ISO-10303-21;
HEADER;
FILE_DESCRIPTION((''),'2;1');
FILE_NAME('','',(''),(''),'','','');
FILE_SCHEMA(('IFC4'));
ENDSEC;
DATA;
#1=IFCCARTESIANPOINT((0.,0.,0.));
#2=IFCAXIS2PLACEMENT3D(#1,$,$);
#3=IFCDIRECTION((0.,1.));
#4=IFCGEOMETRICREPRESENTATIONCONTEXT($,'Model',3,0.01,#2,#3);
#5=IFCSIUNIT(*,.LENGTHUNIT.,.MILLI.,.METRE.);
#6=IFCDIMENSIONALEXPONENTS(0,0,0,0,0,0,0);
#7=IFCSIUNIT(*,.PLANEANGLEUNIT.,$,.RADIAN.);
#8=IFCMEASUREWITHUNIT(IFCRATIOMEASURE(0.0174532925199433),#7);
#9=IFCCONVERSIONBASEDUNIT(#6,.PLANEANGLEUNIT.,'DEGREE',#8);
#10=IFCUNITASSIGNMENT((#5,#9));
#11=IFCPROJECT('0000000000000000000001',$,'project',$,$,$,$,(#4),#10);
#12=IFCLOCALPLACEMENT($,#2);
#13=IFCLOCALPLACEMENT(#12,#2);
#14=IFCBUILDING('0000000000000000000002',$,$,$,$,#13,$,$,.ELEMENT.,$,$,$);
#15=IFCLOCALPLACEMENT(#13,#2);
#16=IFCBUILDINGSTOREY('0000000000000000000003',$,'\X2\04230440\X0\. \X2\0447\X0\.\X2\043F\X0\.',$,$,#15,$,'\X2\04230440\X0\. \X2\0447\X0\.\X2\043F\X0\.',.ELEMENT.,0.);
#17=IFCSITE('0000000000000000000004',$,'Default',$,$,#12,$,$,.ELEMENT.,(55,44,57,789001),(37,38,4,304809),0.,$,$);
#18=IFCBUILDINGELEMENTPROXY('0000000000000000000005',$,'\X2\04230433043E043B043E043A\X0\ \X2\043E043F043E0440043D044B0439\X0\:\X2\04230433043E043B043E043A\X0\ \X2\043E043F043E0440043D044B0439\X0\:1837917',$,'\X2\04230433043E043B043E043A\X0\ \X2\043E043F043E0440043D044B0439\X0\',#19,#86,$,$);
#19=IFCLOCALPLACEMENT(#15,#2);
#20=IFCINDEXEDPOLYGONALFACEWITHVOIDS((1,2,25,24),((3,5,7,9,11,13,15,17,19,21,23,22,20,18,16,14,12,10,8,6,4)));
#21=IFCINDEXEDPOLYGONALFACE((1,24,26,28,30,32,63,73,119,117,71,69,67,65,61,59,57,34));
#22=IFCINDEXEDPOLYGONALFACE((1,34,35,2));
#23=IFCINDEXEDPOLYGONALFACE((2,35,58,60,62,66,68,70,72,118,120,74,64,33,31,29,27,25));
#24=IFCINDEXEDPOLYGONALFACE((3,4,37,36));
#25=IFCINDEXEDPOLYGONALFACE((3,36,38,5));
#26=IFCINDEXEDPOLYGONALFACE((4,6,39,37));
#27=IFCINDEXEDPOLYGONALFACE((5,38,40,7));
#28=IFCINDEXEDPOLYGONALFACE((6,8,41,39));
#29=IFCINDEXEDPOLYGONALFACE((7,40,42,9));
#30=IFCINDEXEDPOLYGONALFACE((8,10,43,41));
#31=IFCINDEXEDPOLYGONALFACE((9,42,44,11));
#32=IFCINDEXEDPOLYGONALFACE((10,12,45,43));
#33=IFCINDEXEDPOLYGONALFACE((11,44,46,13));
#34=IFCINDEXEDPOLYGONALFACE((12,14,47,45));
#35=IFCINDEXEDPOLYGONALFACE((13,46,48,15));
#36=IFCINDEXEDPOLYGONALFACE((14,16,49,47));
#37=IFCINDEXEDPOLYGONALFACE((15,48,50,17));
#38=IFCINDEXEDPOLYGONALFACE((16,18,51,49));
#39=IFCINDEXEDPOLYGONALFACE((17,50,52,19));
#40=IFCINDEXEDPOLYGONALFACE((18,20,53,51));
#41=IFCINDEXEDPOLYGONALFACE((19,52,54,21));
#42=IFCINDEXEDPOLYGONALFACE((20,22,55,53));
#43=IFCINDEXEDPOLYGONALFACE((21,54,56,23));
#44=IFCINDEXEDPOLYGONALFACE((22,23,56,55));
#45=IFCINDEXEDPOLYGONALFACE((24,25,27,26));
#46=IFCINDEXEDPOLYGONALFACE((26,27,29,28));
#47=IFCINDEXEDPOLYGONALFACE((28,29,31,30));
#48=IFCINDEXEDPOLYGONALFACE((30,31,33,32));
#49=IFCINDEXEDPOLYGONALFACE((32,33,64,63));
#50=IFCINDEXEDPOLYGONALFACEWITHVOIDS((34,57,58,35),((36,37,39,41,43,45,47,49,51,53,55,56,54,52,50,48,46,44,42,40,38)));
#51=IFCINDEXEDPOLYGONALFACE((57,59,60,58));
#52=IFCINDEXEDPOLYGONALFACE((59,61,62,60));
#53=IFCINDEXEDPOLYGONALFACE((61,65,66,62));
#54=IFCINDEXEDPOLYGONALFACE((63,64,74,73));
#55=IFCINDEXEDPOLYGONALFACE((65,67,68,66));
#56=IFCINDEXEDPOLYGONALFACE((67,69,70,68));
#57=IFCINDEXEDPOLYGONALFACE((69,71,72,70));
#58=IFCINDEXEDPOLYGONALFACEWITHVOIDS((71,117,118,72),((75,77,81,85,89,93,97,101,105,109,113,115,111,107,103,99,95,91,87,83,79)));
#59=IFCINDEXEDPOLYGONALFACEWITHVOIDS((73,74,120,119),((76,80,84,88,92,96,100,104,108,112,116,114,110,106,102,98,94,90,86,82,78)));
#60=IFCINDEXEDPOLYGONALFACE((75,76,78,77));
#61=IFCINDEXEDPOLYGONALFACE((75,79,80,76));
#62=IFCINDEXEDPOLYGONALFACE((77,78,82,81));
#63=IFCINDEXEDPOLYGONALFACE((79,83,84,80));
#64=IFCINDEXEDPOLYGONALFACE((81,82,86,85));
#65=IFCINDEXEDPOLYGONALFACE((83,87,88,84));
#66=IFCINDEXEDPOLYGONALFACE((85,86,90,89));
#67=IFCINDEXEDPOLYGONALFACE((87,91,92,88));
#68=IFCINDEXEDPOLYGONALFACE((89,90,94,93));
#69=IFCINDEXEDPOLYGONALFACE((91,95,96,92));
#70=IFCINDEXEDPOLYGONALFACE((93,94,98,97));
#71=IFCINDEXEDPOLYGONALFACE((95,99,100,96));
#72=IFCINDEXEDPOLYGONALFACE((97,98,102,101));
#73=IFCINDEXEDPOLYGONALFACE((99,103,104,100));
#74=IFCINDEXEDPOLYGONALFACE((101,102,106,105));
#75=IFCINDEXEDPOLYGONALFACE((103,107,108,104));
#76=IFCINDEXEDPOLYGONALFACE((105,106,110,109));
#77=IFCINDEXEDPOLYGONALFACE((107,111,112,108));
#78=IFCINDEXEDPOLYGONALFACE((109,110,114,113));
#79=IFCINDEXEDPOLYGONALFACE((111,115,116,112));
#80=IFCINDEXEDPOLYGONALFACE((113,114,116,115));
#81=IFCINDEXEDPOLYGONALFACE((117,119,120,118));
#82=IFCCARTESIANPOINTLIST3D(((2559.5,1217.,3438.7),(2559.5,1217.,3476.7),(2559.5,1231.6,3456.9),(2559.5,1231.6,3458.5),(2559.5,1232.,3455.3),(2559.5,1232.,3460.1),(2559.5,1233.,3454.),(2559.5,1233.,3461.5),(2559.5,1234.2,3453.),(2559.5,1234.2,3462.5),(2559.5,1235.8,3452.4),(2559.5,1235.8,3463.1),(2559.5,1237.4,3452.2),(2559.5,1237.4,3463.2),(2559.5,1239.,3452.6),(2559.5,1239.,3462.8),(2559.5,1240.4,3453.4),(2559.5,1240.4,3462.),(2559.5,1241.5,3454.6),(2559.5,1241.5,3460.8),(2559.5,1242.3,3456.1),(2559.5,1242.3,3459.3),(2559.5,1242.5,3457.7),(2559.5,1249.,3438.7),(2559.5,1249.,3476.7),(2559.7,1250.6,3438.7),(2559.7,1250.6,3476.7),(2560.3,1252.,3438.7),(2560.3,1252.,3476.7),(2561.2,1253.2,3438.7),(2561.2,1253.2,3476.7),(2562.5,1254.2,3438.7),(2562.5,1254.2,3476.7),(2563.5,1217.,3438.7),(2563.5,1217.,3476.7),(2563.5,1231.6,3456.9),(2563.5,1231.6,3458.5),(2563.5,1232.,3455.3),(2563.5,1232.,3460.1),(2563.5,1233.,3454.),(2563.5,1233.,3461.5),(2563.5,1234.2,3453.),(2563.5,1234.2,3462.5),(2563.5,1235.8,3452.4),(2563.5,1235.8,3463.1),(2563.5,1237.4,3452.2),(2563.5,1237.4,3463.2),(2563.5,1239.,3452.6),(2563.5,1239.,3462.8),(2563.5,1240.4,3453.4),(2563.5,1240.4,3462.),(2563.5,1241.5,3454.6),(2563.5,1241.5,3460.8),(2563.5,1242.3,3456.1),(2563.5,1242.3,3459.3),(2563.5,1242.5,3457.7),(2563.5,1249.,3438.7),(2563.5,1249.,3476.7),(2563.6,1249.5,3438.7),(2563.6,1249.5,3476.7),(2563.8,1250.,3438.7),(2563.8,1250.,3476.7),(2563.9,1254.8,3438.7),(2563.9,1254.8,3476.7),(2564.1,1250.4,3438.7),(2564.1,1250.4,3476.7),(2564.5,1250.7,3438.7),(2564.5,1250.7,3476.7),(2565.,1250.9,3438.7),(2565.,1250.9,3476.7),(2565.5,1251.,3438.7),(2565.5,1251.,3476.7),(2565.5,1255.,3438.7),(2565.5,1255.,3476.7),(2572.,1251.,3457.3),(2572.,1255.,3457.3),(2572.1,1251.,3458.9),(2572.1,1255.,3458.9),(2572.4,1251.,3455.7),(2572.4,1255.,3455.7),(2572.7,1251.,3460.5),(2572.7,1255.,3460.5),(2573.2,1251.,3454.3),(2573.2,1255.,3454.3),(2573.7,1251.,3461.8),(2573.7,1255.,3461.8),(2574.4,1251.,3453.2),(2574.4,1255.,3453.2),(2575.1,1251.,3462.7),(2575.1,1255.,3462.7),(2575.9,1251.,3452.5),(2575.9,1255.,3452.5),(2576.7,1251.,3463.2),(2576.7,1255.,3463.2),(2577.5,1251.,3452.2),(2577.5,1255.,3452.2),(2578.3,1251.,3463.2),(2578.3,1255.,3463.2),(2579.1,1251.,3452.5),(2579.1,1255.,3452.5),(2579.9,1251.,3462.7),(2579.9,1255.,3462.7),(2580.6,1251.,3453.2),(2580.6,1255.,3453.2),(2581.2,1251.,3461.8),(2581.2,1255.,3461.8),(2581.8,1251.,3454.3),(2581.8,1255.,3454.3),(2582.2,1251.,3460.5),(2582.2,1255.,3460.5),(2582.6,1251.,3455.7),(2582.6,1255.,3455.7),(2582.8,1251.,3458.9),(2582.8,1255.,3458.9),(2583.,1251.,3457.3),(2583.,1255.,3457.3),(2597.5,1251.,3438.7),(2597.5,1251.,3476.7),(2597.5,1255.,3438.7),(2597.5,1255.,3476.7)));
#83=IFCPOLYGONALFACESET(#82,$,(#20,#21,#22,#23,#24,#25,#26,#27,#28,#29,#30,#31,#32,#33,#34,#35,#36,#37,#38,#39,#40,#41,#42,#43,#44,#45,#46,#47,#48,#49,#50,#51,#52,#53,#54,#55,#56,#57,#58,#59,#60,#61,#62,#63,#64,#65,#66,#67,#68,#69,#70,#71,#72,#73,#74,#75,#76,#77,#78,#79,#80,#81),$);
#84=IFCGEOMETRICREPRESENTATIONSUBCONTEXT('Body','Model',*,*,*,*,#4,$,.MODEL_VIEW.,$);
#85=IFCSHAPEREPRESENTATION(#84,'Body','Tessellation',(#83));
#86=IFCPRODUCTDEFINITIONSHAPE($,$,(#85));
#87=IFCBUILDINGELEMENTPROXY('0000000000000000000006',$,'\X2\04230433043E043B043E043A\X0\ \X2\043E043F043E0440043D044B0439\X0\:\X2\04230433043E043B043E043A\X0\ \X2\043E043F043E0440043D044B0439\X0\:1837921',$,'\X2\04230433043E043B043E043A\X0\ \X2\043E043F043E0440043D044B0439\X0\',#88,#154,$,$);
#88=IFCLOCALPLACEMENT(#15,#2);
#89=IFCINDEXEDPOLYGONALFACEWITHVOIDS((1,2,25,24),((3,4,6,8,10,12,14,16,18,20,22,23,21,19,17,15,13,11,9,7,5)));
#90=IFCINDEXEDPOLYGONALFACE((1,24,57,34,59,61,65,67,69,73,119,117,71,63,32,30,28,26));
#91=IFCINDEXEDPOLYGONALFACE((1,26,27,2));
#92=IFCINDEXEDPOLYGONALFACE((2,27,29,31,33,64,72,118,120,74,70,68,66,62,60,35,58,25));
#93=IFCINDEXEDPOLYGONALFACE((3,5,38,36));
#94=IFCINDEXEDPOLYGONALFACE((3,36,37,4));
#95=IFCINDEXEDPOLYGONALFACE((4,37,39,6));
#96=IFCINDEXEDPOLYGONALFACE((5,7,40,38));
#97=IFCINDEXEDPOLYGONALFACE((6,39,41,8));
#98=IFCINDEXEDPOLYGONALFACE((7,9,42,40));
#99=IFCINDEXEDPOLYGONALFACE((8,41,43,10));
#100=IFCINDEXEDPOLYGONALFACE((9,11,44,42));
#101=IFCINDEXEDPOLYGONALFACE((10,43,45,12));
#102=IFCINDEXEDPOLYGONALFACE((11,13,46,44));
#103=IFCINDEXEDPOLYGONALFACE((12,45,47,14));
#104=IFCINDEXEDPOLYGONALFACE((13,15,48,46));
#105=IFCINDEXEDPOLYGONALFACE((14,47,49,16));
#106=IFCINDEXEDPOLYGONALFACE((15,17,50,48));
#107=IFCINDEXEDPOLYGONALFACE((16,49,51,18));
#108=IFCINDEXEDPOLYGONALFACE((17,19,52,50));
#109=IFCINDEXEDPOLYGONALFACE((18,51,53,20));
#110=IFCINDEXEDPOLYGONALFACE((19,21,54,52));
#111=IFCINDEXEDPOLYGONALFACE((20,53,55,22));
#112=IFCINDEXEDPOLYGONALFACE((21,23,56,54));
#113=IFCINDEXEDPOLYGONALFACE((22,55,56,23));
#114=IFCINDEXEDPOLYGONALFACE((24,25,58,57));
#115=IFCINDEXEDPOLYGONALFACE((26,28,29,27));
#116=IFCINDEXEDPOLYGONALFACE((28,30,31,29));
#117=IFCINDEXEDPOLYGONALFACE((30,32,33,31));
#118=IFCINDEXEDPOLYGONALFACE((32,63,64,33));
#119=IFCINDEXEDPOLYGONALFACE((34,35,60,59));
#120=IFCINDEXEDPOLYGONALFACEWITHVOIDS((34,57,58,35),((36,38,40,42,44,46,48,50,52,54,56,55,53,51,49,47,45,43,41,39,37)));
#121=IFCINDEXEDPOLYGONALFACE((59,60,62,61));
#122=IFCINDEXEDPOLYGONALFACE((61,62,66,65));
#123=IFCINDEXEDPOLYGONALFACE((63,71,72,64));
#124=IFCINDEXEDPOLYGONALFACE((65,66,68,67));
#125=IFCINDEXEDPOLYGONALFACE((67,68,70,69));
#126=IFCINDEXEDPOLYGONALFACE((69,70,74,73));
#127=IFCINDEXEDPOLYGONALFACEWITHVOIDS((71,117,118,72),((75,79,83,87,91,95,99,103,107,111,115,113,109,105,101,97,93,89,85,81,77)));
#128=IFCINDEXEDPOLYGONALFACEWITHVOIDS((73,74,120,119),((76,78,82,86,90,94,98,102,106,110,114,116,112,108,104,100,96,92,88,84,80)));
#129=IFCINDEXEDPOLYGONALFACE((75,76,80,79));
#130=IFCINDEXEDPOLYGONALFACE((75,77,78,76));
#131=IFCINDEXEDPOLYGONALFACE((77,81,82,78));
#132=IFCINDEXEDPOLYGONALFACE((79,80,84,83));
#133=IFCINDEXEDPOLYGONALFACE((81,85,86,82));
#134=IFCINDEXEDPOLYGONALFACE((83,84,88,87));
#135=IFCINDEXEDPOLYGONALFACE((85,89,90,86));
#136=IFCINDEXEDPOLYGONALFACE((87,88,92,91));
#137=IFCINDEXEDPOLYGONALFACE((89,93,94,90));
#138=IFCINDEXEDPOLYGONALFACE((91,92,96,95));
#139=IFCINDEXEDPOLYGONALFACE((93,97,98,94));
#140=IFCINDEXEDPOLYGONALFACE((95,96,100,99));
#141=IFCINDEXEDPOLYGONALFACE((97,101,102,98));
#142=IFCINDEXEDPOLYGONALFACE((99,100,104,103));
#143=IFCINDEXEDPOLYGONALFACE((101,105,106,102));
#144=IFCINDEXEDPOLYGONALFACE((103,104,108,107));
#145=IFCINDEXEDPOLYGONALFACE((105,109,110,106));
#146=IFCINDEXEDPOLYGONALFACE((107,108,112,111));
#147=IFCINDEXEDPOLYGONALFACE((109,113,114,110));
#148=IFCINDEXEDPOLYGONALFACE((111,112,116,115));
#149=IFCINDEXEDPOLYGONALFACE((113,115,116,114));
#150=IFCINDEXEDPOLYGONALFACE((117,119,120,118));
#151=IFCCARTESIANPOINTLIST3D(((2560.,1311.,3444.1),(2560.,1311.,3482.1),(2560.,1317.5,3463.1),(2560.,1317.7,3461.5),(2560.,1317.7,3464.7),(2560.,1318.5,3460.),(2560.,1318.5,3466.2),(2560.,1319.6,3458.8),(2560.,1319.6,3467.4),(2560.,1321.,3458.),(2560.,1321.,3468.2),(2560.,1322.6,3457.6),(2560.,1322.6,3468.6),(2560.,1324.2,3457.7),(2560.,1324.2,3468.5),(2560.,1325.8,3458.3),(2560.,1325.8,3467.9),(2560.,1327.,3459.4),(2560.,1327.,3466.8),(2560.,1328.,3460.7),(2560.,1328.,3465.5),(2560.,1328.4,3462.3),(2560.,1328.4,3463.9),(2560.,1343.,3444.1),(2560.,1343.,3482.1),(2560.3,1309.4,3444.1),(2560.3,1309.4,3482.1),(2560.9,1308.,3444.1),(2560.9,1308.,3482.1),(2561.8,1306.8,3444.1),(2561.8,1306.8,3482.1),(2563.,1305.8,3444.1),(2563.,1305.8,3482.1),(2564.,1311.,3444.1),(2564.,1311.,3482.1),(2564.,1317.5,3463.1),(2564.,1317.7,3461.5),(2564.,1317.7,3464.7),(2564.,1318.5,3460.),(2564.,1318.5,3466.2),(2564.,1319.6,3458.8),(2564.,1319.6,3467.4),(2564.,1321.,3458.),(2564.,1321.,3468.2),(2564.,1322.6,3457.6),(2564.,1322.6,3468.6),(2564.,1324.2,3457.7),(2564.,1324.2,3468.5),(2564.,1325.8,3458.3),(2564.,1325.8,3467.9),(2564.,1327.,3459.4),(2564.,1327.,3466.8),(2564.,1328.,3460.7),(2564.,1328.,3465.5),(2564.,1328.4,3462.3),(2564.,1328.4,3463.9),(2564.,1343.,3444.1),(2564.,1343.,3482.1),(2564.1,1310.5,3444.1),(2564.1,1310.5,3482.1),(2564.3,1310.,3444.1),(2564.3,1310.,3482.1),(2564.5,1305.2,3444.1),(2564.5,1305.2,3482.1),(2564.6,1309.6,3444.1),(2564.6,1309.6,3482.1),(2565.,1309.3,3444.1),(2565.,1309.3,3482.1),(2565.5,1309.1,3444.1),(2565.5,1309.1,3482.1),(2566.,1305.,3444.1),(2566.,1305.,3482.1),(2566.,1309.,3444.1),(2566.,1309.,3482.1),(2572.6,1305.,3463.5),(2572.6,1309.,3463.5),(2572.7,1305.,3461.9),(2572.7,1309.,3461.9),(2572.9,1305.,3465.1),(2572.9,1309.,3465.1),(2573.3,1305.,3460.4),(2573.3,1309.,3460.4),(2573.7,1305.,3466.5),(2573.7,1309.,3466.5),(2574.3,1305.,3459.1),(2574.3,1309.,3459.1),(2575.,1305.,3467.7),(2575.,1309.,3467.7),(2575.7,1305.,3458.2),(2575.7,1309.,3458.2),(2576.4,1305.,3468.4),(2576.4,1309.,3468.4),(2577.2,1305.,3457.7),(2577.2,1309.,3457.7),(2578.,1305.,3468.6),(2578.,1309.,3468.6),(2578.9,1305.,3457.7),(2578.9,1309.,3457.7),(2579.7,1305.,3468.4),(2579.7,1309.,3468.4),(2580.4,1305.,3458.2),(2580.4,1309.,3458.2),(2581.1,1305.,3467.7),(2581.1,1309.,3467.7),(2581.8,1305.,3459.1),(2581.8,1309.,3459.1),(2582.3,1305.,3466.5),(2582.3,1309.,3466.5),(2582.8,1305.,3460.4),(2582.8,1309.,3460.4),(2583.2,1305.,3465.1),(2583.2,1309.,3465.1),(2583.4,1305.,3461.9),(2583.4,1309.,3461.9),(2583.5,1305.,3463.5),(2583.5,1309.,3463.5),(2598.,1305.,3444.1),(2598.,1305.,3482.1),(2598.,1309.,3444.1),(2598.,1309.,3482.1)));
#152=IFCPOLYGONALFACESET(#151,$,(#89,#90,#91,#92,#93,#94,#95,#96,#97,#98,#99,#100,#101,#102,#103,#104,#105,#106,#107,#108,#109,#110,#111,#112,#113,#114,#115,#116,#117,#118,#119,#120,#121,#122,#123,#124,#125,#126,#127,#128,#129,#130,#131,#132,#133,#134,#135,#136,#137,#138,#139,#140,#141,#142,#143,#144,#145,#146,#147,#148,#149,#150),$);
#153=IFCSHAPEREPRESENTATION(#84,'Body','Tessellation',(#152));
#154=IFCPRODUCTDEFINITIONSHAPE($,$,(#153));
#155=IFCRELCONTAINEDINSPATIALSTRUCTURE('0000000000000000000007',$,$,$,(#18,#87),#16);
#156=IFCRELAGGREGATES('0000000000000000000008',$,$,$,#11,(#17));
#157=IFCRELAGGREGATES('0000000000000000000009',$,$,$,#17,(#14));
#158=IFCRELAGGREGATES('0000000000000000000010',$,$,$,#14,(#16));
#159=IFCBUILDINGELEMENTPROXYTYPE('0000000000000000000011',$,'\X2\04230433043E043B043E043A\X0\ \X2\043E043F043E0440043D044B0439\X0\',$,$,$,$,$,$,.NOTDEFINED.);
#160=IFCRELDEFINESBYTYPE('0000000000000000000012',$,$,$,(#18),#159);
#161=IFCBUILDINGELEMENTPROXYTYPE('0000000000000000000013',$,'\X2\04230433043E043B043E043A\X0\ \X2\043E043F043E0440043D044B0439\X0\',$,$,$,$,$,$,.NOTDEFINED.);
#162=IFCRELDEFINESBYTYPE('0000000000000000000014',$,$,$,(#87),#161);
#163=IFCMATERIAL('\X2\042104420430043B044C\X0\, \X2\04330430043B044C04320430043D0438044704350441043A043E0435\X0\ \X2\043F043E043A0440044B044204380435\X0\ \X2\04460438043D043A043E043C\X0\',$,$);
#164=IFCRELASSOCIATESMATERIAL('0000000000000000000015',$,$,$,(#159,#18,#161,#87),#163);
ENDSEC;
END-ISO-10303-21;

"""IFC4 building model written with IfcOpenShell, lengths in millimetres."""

from ifc_helpers import new_model, entity, si_unit, converted_unit, direction, frame, frame_2d, origin, place, context, subcontext, project, spatial, polyline, circle_curve, parameter, trimmed, segment, composite_curve, circle, outline, extrude, source, transform, mapped, material, type_object, type_shapes, element, save


model = new_model("IFC4")

# Units and contexts
model_context = context("Model", 3, precision=0.01, world=origin(), true_north=direction((0.0, 1.0)))
body_context = subcontext(model_context, "Body", "Model", "MODEL_VIEW")
ifc_project = project(units=[si_unit("LENGTHUNIT", "METRE", prefix="MILLI"), converted_unit("PLANEANGLEUNIT", "DEGREE", entity("IfcRatioMeasure", 0.0174532925199433), si_unit("PLANEANGLEUNIT", "RADIAN"), dimensions=[0, 0, 0, 0, 0, 0, 0])], contexts=[model_context])

# Site, building, storey
site_placement = place(None, origin())
site = spatial("IfcSite", under=ifc_project, at=site_placement, Name="Default", CompositionType="ELEMENT", RefLatitude=(55, 44, 57, 789001), RefLongitude=(37, 38, 4, 304809), RefElevation=0.0)
building_placement = place(site_placement, origin())
building = spatial("IfcBuilding", under=site, at=building_placement, CompositionType="ELEMENT")
storey_placement = place(building_placement, origin())
storey = spatial("IfcBuildingStorey", under=building, at=storey_placement, Name="Ур. ч.п.", LongName="Ур. ч.п.", CompositionType="ELEMENT", Elevation=0.0)

# Building element proxies, openings
ifc_material = material(Name="Сталь, гальваническое покрытие цинком")
building_element_proxy_type_1 = type_object("IfcBuildingElementProxyType", Name="Уголок опорный", material=ifc_material)
shared_shape_1 = source(origin(), body_context, "Body", "SweptSolid", [
    extrude(outline(composite_curve([segment(polyline([(-6.0, -12.0), (26.0, -12.0)]), True, "CONTINUOUS"), segment(polyline([(26.0, -12.0), (26.0, -8.0)]), True, "CONTINUOUS"), segment(polyline([(26.0, -8.0), (-6.0, -8.0)]), True, "CONTINUOUS"), segment(trimmed(circle_curve(frame_2d((-6.0, -6.0), x_axis=(0.0, -1.0)), 2.0), [parameter(270.0)], [parameter(0.0)], True, "PARAMETER"), False, "CONTINUOUS"), segment(polyline([(-8.0, -6.0), (-8.0, 26.0)]), True, "CONTINUOUS"), segment(polyline([(-8.0, 26.0), (-12.0, 26.0)]), True, "CONTINUOUS"), segment(polyline([(-12.0, 26.0), (-12.0, -6.0)]), True, "CONTINUOUS"), segment(trimmed(circle_curve(frame_2d((-6.0, -6.0), x_axis=(0.0, -1.0)), 6.0), [parameter(270.0)], [parameter(360.0)], True, "PARAMETER"), True, "CONTINUOUS")], self_intersect=False)), frame((12.0, -19.0, 12.0), z_axis=(0.0, 1.0, 0.0), x_axis=(0.0, 0.0, 1.0)), (0.0, 0.0, 1.0), 38.0),
])
type_shapes(building_element_proxy_type_1, [shared_shape_1])
proxy_1_placement = place(storey_placement, frame((2559.5, 1255.0, 3457.7), z_axis=(0.0, -1.0, 0.0), x_axis=(1.0, 0.0, 0.0)))
proxy_1 = element("IfcBuildingElementProxy", 1, at=proxy_1_placement, inside=storey, type_object=building_element_proxy_type_1, material=ifc_material, Name="Уголок опорный:Уголок опорный:1837917", ObjectType="Уголок опорный", context=body_context, shape_type="MappedRepresentation", body=[
    mapped(shared_shape_1, transform((0.0, 0.0, 0.0), scale=1.0)),
])
opening_1_placement = place(storey_placement, frame((2559.5, 1255.0, 3457.7), z_axis=(0.0, 0.0, -1.0), x_axis=(1.0, 0.0, 0.0)))
element("IfcOpeningElement", 2, at=opening_1_placement, cuts=proxy_1, ObjectType="Opening", PredefinedType="OPENING", context=body_context, shape_type="SweptSolid", body=[
    extrude(circle(Radius=5.5, at=frame_2d((0.0, 0.0), x_axis=(1.0, 0.0))), frame((4.0, 18.0, 0.0), z_axis=(-1.0, 0.0, 0.0), x_axis=(0.0, -1.0, 0.0)), (0.0, 0.0, 1.0), 4.0),
])
opening_2_placement = place(storey_placement, frame((2559.5, 1255.0, 3457.7), z_axis=(0.0, 0.0, -1.0), x_axis=(1.0, 0.0, 0.0)))
element("IfcOpeningElement", 3, at=opening_2_placement, cuts=proxy_1, ObjectType="Opening", PredefinedType="OPENING", context=body_context, shape_type="SweptSolid", body=[
    extrude(circle(Radius=5.5, at=frame_2d((0.0, 0.0), x_axis=(1.0, 0.0))), frame((18.0, 0.0, 0.0), z_axis=(0.0, 1.0, 0.0), x_axis=(0.0, 0.0, 1.0)), (0.0, 0.0, 1.0), 4.0),
])
building_element_proxy_type_2 = type_object("IfcBuildingElementProxyType", Name="Уголок опорный", material=ifc_material)
shared_shape_2 = source(origin(), body_context, "Body", "SweptSolid", [
    extrude(outline(composite_curve([segment(polyline([(-6.0, -12.0), (26.0, -12.0)]), True, "CONTINUOUS"), segment(polyline([(26.0, -12.0), (26.0, -8.0)]), True, "CONTINUOUS"), segment(polyline([(26.0, -8.0), (-6.0, -8.0)]), True, "CONTINUOUS"), segment(trimmed(circle_curve(frame_2d((-6.0, -6.0), x_axis=(0.0, -1.0)), 2.0), [parameter(270.0)], [parameter(0.0)], True, "PARAMETER"), False, "CONTINUOUS"), segment(polyline([(-8.0, -6.0), (-8.0, 26.0)]), True, "CONTINUOUS"), segment(polyline([(-8.0, 26.0), (-12.0, 26.0)]), True, "CONTINUOUS"), segment(polyline([(-12.0, 26.0), (-12.0, -6.0)]), True, "CONTINUOUS"), segment(trimmed(circle_curve(frame_2d((-6.0, -6.0), x_axis=(0.0, -1.0)), 6.0), [parameter(270.0)], [parameter(360.0)], True, "PARAMETER"), True, "CONTINUOUS")], self_intersect=False)), frame((12.0, -19.0, 12.0), z_axis=(0.0, 1.0, 0.0), x_axis=(0.0, 0.0, 1.0)), (0.0, 0.0, 1.0), 38.0),
])
type_shapes(building_element_proxy_type_2, [shared_shape_2])
proxy_2_placement = place(storey_placement, frame((2560.0, 1305.0, 3463.1), z_axis=(0.0, 1.0, 0.0), x_axis=(1.0, 0.0, 0.0)))
proxy_2 = element("IfcBuildingElementProxy", 4, at=proxy_2_placement, inside=storey, type_object=building_element_proxy_type_2, material=ifc_material, Name="Уголок опорный:Уголок опорный:1837921", ObjectType="Уголок опорный", context=body_context, shape_type="MappedRepresentation", body=[
    mapped(shared_shape_2, transform((0.0, 0.0, 0.0), scale=1.0)),
])
opening_3_placement = place(storey_placement, frame((2560.0, 1305.0, 3463.1), z_axis=(0.0, 0.0, -1.0), x_axis=(1.0, 0.0, 0.0)))
element("IfcOpeningElement", 5, at=opening_3_placement, cuts=proxy_2, ObjectType="Opening", PredefinedType="OPENING", context=body_context, shape_type="SweptSolid", body=[
    extrude(circle(Radius=5.5, at=frame_2d((0.0, 0.0), x_axis=(1.0, 0.0))), frame((4.0, -18.0, 0.0), z_axis=(-1.0, 0.0, 0.0), x_axis=(0.0, 1.0, 0.0)), (0.0, 0.0, 1.0), 4.0),
])
opening_4_placement = place(storey_placement, frame((2560.0, 1305.0, 3463.1), z_axis=(0.0, 0.0, -1.0), x_axis=(1.0, 0.0, 0.0)))
element("IfcOpeningElement", 6, at=opening_4_placement, cuts=proxy_2, ObjectType="Opening", PredefinedType="OPENING", context=body_context, shape_type="SweptSolid", body=[
    extrude(circle(Radius=5.5, at=frame_2d((0.0, 0.0), x_axis=(1.0, 0.0))), frame((18.0, 0.0, 0.0), z_axis=(0.0, -1.0, 0.0), x_axis=(0.0, 0.0, -1.0)), (0.0, 0.0, 1.0), 4.0),
])

save(model, "model.ifc")
